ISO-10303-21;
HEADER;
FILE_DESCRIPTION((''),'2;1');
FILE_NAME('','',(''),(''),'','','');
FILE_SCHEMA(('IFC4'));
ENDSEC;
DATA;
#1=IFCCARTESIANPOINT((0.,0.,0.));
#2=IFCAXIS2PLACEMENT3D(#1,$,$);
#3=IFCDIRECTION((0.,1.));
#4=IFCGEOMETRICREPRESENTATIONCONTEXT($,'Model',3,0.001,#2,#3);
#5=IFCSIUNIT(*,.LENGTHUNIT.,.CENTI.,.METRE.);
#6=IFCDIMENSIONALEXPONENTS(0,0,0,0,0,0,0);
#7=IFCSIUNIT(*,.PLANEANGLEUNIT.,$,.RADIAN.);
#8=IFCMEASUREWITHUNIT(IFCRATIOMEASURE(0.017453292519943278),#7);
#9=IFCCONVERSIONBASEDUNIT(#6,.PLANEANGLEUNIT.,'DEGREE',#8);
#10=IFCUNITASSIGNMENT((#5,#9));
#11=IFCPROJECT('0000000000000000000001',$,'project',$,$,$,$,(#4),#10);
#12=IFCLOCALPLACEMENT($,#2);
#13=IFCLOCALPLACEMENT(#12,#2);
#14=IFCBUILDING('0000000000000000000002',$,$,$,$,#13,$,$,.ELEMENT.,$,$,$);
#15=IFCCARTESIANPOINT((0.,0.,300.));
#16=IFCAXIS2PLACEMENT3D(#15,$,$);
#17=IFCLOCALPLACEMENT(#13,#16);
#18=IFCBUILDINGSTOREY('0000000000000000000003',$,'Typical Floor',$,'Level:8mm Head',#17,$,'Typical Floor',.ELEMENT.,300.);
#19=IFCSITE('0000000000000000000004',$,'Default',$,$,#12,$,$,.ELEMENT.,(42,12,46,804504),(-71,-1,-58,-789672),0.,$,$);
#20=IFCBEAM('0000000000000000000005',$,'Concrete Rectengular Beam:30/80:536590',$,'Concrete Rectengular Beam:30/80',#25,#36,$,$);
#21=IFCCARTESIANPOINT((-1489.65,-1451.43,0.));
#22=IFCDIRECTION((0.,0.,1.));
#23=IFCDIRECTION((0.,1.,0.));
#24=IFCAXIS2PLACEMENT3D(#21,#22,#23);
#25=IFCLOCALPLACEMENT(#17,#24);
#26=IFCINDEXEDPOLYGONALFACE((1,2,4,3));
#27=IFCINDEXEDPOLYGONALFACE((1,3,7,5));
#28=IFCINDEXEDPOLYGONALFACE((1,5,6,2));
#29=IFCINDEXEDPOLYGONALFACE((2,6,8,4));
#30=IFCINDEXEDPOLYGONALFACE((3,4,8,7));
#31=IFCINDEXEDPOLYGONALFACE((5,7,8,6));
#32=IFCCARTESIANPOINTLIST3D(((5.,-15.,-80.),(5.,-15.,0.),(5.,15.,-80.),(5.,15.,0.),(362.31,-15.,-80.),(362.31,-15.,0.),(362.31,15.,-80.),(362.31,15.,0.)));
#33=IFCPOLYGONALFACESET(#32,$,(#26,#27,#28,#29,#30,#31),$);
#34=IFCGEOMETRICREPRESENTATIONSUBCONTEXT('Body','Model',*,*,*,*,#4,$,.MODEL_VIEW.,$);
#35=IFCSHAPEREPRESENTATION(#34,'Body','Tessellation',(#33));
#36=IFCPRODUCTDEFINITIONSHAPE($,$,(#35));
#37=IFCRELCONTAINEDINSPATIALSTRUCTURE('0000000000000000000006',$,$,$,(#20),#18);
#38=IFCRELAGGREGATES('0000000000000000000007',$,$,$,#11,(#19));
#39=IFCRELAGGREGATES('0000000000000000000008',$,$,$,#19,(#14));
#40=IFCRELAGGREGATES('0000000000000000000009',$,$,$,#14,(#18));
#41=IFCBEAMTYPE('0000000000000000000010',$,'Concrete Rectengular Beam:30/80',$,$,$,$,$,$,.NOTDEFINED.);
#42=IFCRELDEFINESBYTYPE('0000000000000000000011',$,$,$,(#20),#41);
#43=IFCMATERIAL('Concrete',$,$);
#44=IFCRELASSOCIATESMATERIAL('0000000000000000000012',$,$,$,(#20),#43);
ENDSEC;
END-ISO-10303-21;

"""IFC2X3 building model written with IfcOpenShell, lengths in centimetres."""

from ifc_helpers import new_model, entity, si_unit, converted_unit, direction, frame, frame_2d, origin, place, context, subcontext, project, spatial, rectangle, extrude, material, type_object, element, save


model = new_model("IFC2X3")

# Units and contexts
model_context = context("Model", 3, precision=0.001, world=origin(), true_north=direction((0.0, 1.0)))
body_context = subcontext(model_context, "Body", "Model", "MODEL_VIEW")
ifc_project = project(units=[si_unit("LENGTHUNIT", "METRE", prefix="CENTI"), converted_unit("PLANEANGLEUNIT", "DEGREE", entity("IfcRatioMeasure", 0.017453292519943278), si_unit("PLANEANGLEUNIT", "RADIAN"), dimensions=[0, 0, 0, 0, 0, 0, 0])], contexts=[model_context])

# Site, building, storey
site_placement = place(None, origin())
site = spatial("IfcSite", under=ifc_project, at=site_placement, Name="Default", CompositionType="ELEMENT", RefLatitude=(42, 12, 46, 804504), RefLongitude=(-71, -1, -58, -789672), RefElevation=0.0)
building_placement = place(site_placement, origin())
building = spatial("IfcBuilding", under=site, at=building_placement, CompositionType="ELEMENT")
storey_placement = place(building_placement, frame((0.0, 0.0, 300.0)))
storey = spatial("IfcBuildingStorey", under=building, at=storey_placement, Name="Typical Floor", ObjectType="Level:8mm Head", LongName="Typical Floor", CompositionType="ELEMENT", Elevation=300.0)

# Beam
ifc_material = material(Name="Concrete")
beam_type = type_object("IfcBeamType", Name="Concrete Rectengular Beam:30/80", PredefinedType="NOTDEFINED")
beam_1_placement = place(storey_placement, frame((-1489.65, -1451.43, 0.0), z_axis=(0.0, 0.0, 1.0), x_axis=(0.0, 1.0, 0.0)))
element("IfcBeam", 1, at=beam_1_placement, inside=storey, type_object=beam_type, material=ifc_material, Name="Concrete Rectengular Beam:30/80:536590", ObjectType="Concrete Rectengular Beam:30/80", context=body_context, shape_type="SweptSolid", body=[
    extrude(rectangle(XDim=80.0, YDim=30.0, at=frame_2d((0.0, 0.0), x_axis=(1.0, 0.0))), frame((5.0, 0.0, -40.0), z_axis=(1.0, 0.0, 0.0), x_axis=(0.0, 0.0, -1.0)), (0.0, 0.0, 1.0), 357.31),
])

save(model, "model.ifc")
